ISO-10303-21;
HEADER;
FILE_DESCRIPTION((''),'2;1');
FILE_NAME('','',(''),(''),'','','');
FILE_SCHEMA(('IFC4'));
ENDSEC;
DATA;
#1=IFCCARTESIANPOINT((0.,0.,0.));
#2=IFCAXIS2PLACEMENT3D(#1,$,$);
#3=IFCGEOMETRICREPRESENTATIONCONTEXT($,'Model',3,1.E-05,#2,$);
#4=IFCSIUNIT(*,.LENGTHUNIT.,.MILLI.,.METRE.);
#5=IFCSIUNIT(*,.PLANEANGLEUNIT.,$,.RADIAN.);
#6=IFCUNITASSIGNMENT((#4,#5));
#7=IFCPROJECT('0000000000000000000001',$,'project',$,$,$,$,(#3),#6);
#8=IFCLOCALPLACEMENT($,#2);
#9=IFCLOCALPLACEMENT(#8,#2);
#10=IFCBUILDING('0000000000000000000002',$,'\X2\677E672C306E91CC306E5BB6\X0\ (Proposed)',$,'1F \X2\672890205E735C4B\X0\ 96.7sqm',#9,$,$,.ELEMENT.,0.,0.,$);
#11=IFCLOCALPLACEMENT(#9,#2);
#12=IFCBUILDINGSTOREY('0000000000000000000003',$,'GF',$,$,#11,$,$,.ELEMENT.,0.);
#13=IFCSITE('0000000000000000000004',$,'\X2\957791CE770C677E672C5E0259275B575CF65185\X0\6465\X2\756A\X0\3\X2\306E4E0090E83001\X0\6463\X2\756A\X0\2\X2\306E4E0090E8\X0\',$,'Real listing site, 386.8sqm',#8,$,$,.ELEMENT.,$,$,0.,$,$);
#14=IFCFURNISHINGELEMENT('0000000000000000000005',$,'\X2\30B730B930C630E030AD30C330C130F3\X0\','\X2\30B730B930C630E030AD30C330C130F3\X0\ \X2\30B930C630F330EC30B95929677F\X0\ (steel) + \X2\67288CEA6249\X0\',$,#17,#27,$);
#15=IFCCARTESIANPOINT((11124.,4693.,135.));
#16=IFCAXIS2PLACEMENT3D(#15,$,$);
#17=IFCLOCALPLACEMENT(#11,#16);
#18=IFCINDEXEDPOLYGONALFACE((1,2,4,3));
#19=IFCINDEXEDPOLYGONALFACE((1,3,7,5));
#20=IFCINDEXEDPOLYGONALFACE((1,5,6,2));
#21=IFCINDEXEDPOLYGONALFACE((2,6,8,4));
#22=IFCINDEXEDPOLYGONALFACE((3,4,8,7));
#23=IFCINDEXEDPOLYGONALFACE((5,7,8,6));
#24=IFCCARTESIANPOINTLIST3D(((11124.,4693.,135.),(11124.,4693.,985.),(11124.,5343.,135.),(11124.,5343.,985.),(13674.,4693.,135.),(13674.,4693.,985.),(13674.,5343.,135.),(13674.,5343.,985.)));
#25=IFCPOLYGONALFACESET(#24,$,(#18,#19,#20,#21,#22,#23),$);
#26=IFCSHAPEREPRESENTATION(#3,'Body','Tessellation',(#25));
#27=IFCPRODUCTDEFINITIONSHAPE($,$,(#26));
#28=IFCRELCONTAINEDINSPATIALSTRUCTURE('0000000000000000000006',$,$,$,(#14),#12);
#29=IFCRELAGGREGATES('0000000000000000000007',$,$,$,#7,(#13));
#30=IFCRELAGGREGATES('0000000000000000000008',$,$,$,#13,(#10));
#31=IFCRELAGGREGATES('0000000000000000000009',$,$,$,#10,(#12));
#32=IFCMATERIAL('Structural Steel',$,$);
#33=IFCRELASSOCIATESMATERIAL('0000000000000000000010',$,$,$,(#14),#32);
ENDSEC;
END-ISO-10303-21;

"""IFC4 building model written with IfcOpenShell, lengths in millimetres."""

from ifc_helpers import new_model, si_unit, frame, frame_2d, origin, place, context, project, spatial, rectangle, extrude, material, element, save


model = new_model("IFC4")

# Units and contexts
model_context = context("Model", 3, precision=1e-05, world=origin())
ifc_project = project(units=[si_unit("LENGTHUNIT", "METRE", prefix="MILLI"), si_unit("PLANEANGLEUNIT", "RADIAN")], contexts=[model_context])

# Site, building, storey
site_placement = place(None, origin())
site = spatial("IfcSite", under=ifc_project, at=site_placement, Name="長野県松本市大字島内6465番3の一部、6463番2の一部", ObjectType="Real listing site, 386.8sqm", CompositionType="ELEMENT", RefElevation=0.0)
building_placement = place(site_placement, origin())
building = spatial("IfcBuilding", under=site, at=building_placement, Name="松本の里の家 (Proposed)", ObjectType="1F 木造平屋 96.7sqm", CompositionType="ELEMENT", ElevationOfRefHeight=0.0, ElevationOfTerrain=0.0)
storey_placement = place(building_placement, origin())
storey = spatial("IfcBuildingStorey", under=building, at=storey_placement, Name="GF", CompositionType="ELEMENT", Elevation=0.0)

# Furnishing element
ifc_material_1 = material(Name="Structural Steel")
furnishing_1_placement = place(storey_placement, frame((11124.0, 4693.0, 135.0)))
element("IfcFurnishingElement", 1, at=furnishing_1_placement, inside=storey, material=ifc_material_1, Name="システムキッチン", Description="システムキッチン ステンレス天板 (steel) + 木質扉", context=model_context, shape_type="SweptSolid", body=[
    extrude(rectangle(XDim=2550.0, YDim=650.0, at=frame_2d((1275.0, 325.0))), frame((11124.0, 4693.0, 135.0)), (0.0, 0.0, 1.0), 850.0),
])

save(model, "model.ifc")
